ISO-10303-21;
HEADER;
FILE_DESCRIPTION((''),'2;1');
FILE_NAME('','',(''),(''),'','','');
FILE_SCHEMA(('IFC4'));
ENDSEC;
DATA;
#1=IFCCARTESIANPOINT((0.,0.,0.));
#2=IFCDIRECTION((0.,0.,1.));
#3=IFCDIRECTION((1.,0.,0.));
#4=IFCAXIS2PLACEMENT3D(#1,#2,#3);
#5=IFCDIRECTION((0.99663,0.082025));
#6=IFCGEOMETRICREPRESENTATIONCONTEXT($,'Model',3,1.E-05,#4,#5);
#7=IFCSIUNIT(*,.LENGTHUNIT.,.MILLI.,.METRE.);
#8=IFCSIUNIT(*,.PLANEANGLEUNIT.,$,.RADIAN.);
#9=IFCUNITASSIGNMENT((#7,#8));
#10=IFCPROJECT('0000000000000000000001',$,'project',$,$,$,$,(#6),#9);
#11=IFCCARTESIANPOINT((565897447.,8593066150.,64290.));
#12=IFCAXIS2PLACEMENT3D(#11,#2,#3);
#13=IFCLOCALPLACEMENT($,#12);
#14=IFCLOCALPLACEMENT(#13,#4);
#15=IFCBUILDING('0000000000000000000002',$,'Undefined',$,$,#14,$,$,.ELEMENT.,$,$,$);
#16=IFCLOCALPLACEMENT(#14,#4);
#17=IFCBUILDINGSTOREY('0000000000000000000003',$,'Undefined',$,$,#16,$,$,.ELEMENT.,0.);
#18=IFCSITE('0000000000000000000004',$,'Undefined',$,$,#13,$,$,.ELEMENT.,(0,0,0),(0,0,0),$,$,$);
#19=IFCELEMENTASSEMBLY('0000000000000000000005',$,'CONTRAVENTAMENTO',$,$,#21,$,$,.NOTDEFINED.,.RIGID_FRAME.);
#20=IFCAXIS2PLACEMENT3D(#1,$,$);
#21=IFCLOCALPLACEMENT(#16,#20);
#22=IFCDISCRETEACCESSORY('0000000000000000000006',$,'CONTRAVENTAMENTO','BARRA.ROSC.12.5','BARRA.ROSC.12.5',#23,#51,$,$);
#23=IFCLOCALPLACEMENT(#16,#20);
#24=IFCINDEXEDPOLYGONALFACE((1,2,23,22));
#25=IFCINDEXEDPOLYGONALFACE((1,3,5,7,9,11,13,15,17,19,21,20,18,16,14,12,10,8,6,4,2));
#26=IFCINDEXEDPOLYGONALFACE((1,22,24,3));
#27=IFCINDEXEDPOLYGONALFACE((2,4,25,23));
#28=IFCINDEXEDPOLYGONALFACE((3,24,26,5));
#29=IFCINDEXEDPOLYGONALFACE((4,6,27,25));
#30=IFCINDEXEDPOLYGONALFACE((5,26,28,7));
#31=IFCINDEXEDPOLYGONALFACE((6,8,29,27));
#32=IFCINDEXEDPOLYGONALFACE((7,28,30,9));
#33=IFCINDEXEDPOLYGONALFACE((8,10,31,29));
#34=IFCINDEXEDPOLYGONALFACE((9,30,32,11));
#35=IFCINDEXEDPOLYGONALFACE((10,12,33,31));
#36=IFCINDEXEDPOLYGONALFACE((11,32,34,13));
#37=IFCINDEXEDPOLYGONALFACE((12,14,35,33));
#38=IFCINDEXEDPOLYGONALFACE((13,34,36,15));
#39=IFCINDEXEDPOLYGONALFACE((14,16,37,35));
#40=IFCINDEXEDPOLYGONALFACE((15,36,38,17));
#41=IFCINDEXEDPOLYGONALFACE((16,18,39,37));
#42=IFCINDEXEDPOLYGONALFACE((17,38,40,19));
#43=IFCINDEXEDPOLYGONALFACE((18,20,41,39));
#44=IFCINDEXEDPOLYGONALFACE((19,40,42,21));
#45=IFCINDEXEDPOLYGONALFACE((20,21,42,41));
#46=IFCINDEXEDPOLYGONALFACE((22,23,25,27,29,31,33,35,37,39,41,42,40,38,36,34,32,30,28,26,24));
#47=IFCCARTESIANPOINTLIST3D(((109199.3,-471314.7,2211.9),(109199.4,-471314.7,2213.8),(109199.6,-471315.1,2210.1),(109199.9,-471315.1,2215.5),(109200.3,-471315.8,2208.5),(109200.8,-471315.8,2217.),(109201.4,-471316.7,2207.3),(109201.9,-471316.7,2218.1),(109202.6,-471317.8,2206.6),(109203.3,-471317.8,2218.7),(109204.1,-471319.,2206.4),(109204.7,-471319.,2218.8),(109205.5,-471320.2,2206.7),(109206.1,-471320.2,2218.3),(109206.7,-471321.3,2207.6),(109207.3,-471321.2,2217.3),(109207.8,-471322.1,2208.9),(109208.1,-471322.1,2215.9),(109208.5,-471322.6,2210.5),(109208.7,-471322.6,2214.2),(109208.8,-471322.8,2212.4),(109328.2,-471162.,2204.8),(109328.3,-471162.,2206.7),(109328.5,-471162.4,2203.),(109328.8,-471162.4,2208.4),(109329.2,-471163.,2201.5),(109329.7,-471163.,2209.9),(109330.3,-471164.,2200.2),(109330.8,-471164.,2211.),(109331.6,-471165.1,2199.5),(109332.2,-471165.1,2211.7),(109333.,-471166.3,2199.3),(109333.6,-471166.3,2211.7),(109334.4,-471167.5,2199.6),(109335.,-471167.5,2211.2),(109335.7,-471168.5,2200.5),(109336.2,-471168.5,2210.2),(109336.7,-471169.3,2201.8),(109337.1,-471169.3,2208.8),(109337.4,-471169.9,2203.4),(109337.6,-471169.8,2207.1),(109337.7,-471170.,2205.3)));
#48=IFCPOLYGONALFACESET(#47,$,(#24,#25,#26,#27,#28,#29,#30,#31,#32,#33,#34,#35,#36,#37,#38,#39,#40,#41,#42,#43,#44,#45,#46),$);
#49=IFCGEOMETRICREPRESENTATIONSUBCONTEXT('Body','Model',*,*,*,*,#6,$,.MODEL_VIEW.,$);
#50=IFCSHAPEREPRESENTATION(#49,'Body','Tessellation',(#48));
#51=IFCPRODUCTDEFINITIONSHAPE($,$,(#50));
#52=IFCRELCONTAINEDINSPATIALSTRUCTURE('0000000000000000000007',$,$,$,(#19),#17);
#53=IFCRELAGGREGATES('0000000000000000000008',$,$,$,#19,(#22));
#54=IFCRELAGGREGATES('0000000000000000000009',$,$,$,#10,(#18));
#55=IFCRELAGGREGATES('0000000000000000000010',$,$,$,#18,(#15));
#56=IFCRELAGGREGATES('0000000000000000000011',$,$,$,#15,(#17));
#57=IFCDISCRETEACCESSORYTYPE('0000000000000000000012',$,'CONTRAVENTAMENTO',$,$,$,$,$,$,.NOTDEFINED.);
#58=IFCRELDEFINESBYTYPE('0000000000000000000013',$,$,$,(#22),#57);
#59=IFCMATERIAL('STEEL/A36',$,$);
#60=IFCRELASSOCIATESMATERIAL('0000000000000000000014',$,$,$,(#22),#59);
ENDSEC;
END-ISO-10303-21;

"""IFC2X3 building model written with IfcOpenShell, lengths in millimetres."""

from ifc_helpers import new_model, si_unit, direction, frame, frame_2d, origin_with_axes, place, context, subcontext, project, spatial, circle, extrude, material, type_object, element, aggregate, save


model = new_model("IFC2X3")

# Units and contexts
model_context = context("Model", 3, precision=1e-05, world=origin_with_axes(), true_north=direction((0.99663, 0.082025)))
body_context = subcontext(model_context, "Body", "Model", "MODEL_VIEW")
ifc_project = project(units=[si_unit("LENGTHUNIT", "METRE", prefix="MILLI"), si_unit("PLANEANGLEUNIT", "RADIAN")], contexts=[model_context])

# Site, building, storey
site_placement = place(None, frame((565897447.0, 8593066150.0, 64290.0), z_axis=(0.0, 0.0, 1.0), x_axis=(1.0, 0.0, 0.0)))
site = spatial("IfcSite", under=ifc_project, at=site_placement, Name="Undefined", CompositionType="ELEMENT", RefLatitude=(0, 0, 0), RefLongitude=(0, 0, 0))
building_placement = place(site_placement, origin_with_axes())
building = spatial("IfcBuilding", under=site, at=building_placement, Name="Undefined", CompositionType="ELEMENT")
storey_placement = place(building_placement, origin_with_axes())
storey = spatial("IfcBuildingStorey", under=building, at=storey_placement, Name="Undefined", CompositionType="ELEMENT", Elevation=0.0)

# Shared definitions
ifc_material_1 = material(Name="STEEL/A36")

# Element assembly, discrete accessory
discrete_accessory_type_1 = type_object("IfcDiscreteAccessoryType", Name="CONTRAVENTAMENTO")
assembly_1_placement = place(storey_placement, origin_with_axes())
assembly_1 = element("IfcElementAssembly", 1, at=assembly_1_placement, inside=storey, Name="CONTRAVENTAMENTO", AssemblyPlace="NOTDEFINED", PredefinedType="RIGID_FRAME")
discrete_accessory_1_placement = place(assembly_1_placement, frame((109332.9, -471166.0, 2205.5), z_axis=(-0.764529, 0.643627, -0.035208), x_axis=(-0.644577, -0.763719, 0.035414)))
discrete_accessory_1 = element("IfcDiscreteAccessory", 2, at=discrete_accessory_1_placement, type_object=discrete_accessory_type_1, material=ifc_material_1, Name="CONTRAVENTAMENTO", Description="BARRA.ROSC.12.5", ObjectType="BARRA.ROSC.12.5", context=body_context, shape_type="SweptSolid", body=[
    extrude(circle(Radius=6.2, at=frame_2d((0.0, 0.0), x_axis=(1.0, 0.0))), frame((200.0, 0.0, 0.0), z_axis=(-1.0, 0.0, 0.0), x_axis=(0.0, -1.0, 0.0)), (0.0, 0.0, 1.0), 200.0),
])
aggregate(assembly_1, [discrete_accessory_1])

save(model, "model.ifc")
